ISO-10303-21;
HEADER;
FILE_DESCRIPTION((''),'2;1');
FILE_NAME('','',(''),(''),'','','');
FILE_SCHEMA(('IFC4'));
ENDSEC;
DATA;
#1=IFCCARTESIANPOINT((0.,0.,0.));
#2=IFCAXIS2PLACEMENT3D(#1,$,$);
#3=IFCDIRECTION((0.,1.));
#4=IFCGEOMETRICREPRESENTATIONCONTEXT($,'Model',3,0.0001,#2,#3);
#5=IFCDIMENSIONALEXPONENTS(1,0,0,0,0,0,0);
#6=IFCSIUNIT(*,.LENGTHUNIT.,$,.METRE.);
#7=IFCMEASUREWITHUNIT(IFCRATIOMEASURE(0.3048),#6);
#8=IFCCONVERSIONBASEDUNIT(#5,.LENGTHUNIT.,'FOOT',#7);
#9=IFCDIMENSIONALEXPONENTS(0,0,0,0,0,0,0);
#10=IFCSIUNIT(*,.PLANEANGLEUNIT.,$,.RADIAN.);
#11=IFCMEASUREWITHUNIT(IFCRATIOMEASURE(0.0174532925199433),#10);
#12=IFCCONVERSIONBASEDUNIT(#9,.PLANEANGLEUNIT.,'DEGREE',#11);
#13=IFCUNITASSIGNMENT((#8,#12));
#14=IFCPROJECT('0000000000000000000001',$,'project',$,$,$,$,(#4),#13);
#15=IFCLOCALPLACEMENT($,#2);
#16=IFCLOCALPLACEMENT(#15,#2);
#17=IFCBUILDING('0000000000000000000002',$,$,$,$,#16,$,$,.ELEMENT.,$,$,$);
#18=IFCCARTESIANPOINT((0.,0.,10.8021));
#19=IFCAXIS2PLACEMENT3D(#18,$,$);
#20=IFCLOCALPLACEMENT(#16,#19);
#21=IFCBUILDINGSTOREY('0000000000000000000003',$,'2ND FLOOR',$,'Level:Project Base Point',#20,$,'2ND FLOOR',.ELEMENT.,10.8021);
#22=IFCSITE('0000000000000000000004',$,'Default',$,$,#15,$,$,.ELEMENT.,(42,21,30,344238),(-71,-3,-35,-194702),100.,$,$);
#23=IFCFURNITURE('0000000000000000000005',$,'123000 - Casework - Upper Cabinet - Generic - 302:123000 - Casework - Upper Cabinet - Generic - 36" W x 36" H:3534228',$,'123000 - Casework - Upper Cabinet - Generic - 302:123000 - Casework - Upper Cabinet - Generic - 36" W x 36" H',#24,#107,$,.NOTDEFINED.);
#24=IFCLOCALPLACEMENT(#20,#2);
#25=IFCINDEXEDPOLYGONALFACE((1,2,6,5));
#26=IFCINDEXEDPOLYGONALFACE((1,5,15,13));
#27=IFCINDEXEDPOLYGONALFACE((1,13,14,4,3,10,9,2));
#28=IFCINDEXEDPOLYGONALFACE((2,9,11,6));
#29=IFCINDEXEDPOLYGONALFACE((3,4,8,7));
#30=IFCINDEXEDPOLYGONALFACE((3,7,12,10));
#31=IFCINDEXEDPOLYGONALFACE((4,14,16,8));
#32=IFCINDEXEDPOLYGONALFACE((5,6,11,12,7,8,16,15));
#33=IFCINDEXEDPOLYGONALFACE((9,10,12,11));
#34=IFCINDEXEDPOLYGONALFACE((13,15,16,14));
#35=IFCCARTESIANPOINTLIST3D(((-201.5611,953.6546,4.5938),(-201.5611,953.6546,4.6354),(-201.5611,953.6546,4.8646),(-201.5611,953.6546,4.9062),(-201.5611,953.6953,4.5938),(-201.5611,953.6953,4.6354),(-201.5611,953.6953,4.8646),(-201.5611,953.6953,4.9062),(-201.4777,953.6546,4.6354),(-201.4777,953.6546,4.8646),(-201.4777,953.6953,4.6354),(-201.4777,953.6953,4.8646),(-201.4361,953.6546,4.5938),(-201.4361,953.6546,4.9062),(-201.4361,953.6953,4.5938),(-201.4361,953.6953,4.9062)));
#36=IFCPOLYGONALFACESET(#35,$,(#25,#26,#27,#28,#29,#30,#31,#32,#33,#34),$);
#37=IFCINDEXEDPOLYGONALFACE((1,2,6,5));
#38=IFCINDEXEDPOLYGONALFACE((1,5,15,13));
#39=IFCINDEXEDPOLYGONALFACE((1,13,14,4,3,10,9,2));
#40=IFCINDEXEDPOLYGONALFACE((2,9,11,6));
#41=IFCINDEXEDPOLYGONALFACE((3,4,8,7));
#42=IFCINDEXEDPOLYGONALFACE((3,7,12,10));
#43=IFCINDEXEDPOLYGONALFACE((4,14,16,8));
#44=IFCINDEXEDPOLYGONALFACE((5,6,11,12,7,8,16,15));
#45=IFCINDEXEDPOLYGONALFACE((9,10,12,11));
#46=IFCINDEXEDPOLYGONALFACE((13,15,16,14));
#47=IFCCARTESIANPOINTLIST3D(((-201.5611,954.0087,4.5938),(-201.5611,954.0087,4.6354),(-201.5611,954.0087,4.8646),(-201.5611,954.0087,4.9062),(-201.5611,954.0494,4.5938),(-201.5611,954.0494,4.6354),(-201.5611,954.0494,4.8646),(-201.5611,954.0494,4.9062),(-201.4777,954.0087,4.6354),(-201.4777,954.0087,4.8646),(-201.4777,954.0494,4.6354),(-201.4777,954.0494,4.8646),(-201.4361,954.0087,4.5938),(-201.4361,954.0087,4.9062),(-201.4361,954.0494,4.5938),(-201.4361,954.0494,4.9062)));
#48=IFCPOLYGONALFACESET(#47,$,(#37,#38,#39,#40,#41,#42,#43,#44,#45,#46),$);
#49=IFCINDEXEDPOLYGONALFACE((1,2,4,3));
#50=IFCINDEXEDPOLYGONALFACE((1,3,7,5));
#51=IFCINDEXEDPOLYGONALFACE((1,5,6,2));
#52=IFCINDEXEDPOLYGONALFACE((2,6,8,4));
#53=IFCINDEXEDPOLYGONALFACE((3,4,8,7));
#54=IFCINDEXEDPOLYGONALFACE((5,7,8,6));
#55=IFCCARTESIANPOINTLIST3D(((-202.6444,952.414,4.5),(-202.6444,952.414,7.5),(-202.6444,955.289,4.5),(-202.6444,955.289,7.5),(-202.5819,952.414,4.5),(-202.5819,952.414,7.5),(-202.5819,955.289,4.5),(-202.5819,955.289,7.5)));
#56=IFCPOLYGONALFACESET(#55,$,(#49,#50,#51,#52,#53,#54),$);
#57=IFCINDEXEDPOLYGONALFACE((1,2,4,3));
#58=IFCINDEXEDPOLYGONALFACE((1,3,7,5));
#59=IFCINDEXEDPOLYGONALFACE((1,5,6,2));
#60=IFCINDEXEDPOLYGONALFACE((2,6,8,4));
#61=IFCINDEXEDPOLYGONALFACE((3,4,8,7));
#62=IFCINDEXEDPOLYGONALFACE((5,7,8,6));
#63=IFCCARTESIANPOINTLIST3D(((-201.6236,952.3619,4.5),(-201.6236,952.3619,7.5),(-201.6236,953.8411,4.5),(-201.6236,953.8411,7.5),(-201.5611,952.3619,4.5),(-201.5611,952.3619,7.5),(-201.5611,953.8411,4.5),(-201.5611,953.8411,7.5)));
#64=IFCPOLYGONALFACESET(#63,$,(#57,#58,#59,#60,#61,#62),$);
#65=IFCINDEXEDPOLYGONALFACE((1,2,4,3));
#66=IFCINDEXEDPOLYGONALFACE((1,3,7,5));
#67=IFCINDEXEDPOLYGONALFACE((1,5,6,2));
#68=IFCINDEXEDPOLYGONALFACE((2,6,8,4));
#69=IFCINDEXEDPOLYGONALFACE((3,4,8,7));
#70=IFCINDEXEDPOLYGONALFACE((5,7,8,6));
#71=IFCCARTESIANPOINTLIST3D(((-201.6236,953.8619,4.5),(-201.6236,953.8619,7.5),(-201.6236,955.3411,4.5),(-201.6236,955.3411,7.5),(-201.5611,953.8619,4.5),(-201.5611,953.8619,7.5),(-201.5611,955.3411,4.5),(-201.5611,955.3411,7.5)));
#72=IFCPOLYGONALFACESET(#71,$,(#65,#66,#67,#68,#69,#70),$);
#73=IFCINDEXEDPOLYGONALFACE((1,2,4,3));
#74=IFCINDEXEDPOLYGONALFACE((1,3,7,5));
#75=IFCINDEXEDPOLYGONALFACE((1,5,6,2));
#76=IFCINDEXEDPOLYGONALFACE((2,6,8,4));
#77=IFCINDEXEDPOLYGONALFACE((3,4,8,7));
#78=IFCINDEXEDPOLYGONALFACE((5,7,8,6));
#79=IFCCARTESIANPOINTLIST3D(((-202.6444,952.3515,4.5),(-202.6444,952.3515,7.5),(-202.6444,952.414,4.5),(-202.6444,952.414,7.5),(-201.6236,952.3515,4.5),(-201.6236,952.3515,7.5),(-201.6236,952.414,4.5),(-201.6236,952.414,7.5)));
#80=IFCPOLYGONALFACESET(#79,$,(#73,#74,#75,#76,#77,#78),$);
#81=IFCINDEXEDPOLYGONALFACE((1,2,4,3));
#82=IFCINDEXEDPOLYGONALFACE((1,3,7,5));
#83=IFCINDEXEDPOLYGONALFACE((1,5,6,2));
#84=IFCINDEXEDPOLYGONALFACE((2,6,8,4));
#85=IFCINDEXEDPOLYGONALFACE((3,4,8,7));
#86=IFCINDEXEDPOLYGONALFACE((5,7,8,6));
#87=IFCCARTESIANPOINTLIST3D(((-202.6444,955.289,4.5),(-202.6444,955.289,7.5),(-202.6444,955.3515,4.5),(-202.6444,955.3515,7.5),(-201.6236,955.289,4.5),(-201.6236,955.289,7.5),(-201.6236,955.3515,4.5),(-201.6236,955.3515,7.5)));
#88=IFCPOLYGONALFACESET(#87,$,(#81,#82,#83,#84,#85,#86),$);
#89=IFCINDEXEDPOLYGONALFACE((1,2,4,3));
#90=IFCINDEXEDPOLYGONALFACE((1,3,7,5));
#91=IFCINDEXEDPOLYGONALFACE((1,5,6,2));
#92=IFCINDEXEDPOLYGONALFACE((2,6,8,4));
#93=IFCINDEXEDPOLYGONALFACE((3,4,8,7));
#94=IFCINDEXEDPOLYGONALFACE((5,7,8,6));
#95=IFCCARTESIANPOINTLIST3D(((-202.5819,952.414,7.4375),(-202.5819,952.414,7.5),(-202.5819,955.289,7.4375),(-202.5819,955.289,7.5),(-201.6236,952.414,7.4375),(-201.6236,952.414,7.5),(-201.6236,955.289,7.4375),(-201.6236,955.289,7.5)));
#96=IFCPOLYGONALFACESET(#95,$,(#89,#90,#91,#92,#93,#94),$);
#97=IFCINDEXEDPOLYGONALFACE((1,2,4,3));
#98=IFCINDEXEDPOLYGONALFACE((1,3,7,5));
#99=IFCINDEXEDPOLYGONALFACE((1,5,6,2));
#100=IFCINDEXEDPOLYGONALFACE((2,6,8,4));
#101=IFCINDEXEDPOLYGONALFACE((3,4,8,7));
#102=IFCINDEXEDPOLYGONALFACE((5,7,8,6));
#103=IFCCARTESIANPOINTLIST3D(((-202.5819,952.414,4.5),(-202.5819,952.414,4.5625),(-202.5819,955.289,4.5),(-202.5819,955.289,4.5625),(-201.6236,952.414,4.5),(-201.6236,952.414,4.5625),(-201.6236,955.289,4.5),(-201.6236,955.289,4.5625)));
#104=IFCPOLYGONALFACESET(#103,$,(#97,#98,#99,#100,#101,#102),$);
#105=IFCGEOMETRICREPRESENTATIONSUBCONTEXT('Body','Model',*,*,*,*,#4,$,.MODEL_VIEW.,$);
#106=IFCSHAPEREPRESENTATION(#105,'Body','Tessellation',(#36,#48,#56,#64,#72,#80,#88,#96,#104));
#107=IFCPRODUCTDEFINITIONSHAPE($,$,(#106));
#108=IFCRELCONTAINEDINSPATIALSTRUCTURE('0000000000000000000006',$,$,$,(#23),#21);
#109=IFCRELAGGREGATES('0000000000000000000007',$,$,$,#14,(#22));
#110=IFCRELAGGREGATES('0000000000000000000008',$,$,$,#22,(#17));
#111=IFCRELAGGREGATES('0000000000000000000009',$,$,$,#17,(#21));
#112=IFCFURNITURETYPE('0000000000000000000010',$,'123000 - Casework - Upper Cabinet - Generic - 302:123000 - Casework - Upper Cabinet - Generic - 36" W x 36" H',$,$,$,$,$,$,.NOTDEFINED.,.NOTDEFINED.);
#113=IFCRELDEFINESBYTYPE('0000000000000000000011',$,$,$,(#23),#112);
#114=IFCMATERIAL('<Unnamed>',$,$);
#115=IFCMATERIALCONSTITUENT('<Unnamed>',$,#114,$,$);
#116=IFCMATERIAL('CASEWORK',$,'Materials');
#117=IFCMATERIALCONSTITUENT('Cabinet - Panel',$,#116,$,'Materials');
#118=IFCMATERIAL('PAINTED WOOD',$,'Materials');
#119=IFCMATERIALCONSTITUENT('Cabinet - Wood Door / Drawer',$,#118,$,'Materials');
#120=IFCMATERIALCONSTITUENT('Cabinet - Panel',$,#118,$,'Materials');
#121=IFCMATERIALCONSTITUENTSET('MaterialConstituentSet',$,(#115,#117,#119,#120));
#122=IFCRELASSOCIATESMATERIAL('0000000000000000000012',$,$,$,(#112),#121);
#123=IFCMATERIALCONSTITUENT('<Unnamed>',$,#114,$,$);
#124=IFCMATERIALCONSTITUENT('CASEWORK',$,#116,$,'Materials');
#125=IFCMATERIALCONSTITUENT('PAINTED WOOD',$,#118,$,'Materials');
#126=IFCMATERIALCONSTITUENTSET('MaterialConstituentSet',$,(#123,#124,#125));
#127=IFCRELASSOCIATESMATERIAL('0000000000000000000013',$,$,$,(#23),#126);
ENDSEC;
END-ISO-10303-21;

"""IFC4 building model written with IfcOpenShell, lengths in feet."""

from ifc_helpers import new_model, entity, si_unit, converted_unit, direction, frame, frame_2d, origin, origin_2d_with_axis, place, context, subcontext, project, spatial, polyline, rectangle, outline, extrude, source, transform, mapped, material, constituent, constituent_set, type_object, type_shapes, element, save


model = new_model("IFC4")

# Units and contexts
model_context = context("Model", 3, precision=0.0001, world=origin(), true_north=direction((0.0, 1.0)))
body_context = subcontext(model_context, "Body", "Model", "MODEL_VIEW")
ifc_project = project(units=[converted_unit("LENGTHUNIT", "FOOT", entity("IfcRatioMeasure", 0.3048), si_unit("LENGTHUNIT", "METRE"), dimensions=[1, 0, 0, 0, 0, 0, 0]), converted_unit("PLANEANGLEUNIT", "DEGREE", entity("IfcRatioMeasure", 0.0174532925199433), si_unit("PLANEANGLEUNIT", "RADIAN"), dimensions=[0, 0, 0, 0, 0, 0, 0])], contexts=[model_context])

# Site, building, storey
site_placement = place(None, origin())
site = spatial("IfcSite", under=ifc_project, at=site_placement, Name="Default", CompositionType="ELEMENT", RefLatitude=(42, 21, 30, 344238), RefLongitude=(-71, -3, -35, -194702), RefElevation=100.0)
building_placement = place(site_placement, origin())
building = spatial("IfcBuilding", under=site, at=building_placement, CompositionType="ELEMENT")
storey_placement = place(building_placement, frame((0.0, 0.0, 10.8021)))
storey = spatial("IfcBuildingStorey", under=building, at=storey_placement, Name="2ND FLOOR", ObjectType="Level:Project Base Point", LongName="2ND FLOOR", CompositionType="ELEMENT", Elevation=10.8021)

# Furniture
ifc_material_1 = material(Name="CASEWORK", Category="Materials")
ifc_material_2 = material(Name="PAINTED WOOD", Category="Materials")
ifc_material_3 = material(Name="<Unnamed>")
ifc_constituent_1 = constituent(ifc_material_3, Name="<Unnamed>")
ifc_constituent_2 = constituent(ifc_material_1, Name="CASEWORK", Category="Materials")
ifc_constituent_3 = constituent(ifc_material_2, Name="PAINTED WOOD", Category="Materials")
ifc_constituent_set_1 = constituent_set(constituents=[ifc_constituent_1, ifc_constituent_2, ifc_constituent_3], Name="MaterialConstituentSet")
ifc_constituent_4 = constituent(ifc_material_3, Name="<Unnamed>")
ifc_constituent_5 = constituent(ifc_material_1, Name="Cabinet - Panel", Category="Materials")
ifc_constituent_6 = constituent(ifc_material_2, Name="Cabinet - Wood Door / Drawer", Category="Materials")
ifc_constituent_7 = constituent(ifc_material_2, Name="Cabinet - Panel", Category="Materials")
ifc_constituent_set_2 = constituent_set(constituents=[ifc_constituent_4, ifc_constituent_5, ifc_constituent_6, ifc_constituent_7], Name="MaterialConstituentSet")
furniture_type_1 = type_object("IfcFurnitureType", Name="123000 - Casework - Upper Cabinet - Generic - 302:123000 - Casework - Upper Cabinet - Generic - 36\" W x 36\" H", AssemblyPlace="NOTDEFINED", PredefinedType="NOTDEFINED", material=ifc_constituent_set_2)
shared_shape_1 = source(origin(), body_context, "Body", "SweptSolid", [
    extrude(outline(polyline([(0.1146, -0.0521), (0.1562, -0.0521), (0.1562, 0.0729), (-0.1562, 0.0729), (-0.1562, -0.0521), (-0.1146, -0.0521), (-0.1146, 0.0313), (0.1146, 0.0313), (0.1146, -0.0521)])), frame((1.303, 0.0729, 0.25), z_axis=(1.0, 0.0, 0.0), x_axis=(0.0, 0.0, 1.0)), (0.0, 0.0, 1.0), 0.0407),
    extrude(outline(polyline([(0.1146, -0.0521), (0.1562, -0.0521), (0.1562, 0.0729), (-0.1562, 0.0729), (-0.1562, -0.0521), (-0.1146, -0.0521), (-0.1146, 0.0313), (0.1146, 0.0313), (0.1146, -0.0521)])), frame((1.6572, 0.0729, 0.25), z_axis=(1.0, 0.0, 0.0), x_axis=(0.0, 0.0, 1.0)), (0.0, 0.0, 1.0), 0.0407),
    extrude(rectangle(XDim=0.0625, YDim=2.875, at=origin_2d_with_axis()), frame((1.5, 1.177, 0.0), z_axis=(0.0, 0.0, 1.0), x_axis=(0.0, 1.0, 0.0)), (0.0, 0.0, 1.0), 3.0),
    extrude(rectangle(XDim=0.0625, YDim=1.4792, at=frame_2d((0.0, 0.0), x_axis=(1.0, 0.0))), frame((0.75, 0.1562, 0.0), z_axis=(0.0, 0.0, 1.0), x_axis=(0.0, -1.0, 0.0)), (0.0, 0.0, 1.0), 3.0),
    extrude(rectangle(XDim=0.0625, YDim=1.4792, at=origin_2d_with_axis()), frame((2.25, 0.1562, 0.0), z_axis=(0.0, 0.0, 1.0), x_axis=(0.0, -1.0, 0.0)), (0.0, 0.0, 1.0), 3.0),
    extrude(rectangle(XDim=0.0625, YDim=1.0208, at=origin_2d_with_axis()), frame((0.0312, 0.6979, 0.0), z_axis=(0.0, 0.0, 1.0), x_axis=(-1.0, 0.0, 0.0)), (0.0, 0.0, 1.0), 3.0),
    extrude(rectangle(XDim=0.0625, YDim=1.0208, at=origin_2d_with_axis()), frame((2.9688, 0.6979, 0.0), z_axis=(0.0, 0.0, 1.0), x_axis=(-1.0, 0.0, 0.0)), (0.0, 0.0, 1.0), 3.0),
    extrude(rectangle(XDim=2.875, YDim=0.9583, at=frame_2d((0.0, 0.0), x_axis=(1.0, 0.0))), frame((1.5, 0.6666, 2.9375), z_axis=(0.0, 0.0, 1.0), x_axis=(-1.0, 0.0, 0.0)), (0.0, 0.0, 1.0), 0.0625),
    extrude(rectangle(XDim=2.875, YDim=0.9583, at=frame_2d((0.0, 0.0), x_axis=(1.0, 0.0))), frame((1.5, 0.6666, 0.0), z_axis=(0.0, 0.0, 1.0), x_axis=(-1.0, 0.0, 0.0)), (0.0, 0.0, 1.0), 0.0625),
])
type_shapes(furniture_type_1, [shared_shape_1])
furniture_1_placement = place(storey_placement, frame((-201.4361, 952.3515, 4.5), z_axis=(0.0, 0.0, 1.0), x_axis=(0.0, 1.0, 0.0)))
element("IfcFurniture", 1, at=furniture_1_placement, inside=storey, type_object=furniture_type_1, material=ifc_constituent_set_1, Name="123000 - Casework - Upper Cabinet - Generic - 302:123000 - Casework - Upper Cabinet - Generic - 36\" W x 36\" H:3534228", ObjectType="123000 - Casework - Upper Cabinet - Generic - 302:123000 - Casework - Upper Cabinet - Generic - 36\" W x 36\" H", PredefinedType="NOTDEFINED", context=body_context, shape_type="MappedRepresentation", body=[
    mapped(shared_shape_1, transform((0.0, 0.0, 0.0), scale=1.0)),
])

save(model, "model.ifc")
